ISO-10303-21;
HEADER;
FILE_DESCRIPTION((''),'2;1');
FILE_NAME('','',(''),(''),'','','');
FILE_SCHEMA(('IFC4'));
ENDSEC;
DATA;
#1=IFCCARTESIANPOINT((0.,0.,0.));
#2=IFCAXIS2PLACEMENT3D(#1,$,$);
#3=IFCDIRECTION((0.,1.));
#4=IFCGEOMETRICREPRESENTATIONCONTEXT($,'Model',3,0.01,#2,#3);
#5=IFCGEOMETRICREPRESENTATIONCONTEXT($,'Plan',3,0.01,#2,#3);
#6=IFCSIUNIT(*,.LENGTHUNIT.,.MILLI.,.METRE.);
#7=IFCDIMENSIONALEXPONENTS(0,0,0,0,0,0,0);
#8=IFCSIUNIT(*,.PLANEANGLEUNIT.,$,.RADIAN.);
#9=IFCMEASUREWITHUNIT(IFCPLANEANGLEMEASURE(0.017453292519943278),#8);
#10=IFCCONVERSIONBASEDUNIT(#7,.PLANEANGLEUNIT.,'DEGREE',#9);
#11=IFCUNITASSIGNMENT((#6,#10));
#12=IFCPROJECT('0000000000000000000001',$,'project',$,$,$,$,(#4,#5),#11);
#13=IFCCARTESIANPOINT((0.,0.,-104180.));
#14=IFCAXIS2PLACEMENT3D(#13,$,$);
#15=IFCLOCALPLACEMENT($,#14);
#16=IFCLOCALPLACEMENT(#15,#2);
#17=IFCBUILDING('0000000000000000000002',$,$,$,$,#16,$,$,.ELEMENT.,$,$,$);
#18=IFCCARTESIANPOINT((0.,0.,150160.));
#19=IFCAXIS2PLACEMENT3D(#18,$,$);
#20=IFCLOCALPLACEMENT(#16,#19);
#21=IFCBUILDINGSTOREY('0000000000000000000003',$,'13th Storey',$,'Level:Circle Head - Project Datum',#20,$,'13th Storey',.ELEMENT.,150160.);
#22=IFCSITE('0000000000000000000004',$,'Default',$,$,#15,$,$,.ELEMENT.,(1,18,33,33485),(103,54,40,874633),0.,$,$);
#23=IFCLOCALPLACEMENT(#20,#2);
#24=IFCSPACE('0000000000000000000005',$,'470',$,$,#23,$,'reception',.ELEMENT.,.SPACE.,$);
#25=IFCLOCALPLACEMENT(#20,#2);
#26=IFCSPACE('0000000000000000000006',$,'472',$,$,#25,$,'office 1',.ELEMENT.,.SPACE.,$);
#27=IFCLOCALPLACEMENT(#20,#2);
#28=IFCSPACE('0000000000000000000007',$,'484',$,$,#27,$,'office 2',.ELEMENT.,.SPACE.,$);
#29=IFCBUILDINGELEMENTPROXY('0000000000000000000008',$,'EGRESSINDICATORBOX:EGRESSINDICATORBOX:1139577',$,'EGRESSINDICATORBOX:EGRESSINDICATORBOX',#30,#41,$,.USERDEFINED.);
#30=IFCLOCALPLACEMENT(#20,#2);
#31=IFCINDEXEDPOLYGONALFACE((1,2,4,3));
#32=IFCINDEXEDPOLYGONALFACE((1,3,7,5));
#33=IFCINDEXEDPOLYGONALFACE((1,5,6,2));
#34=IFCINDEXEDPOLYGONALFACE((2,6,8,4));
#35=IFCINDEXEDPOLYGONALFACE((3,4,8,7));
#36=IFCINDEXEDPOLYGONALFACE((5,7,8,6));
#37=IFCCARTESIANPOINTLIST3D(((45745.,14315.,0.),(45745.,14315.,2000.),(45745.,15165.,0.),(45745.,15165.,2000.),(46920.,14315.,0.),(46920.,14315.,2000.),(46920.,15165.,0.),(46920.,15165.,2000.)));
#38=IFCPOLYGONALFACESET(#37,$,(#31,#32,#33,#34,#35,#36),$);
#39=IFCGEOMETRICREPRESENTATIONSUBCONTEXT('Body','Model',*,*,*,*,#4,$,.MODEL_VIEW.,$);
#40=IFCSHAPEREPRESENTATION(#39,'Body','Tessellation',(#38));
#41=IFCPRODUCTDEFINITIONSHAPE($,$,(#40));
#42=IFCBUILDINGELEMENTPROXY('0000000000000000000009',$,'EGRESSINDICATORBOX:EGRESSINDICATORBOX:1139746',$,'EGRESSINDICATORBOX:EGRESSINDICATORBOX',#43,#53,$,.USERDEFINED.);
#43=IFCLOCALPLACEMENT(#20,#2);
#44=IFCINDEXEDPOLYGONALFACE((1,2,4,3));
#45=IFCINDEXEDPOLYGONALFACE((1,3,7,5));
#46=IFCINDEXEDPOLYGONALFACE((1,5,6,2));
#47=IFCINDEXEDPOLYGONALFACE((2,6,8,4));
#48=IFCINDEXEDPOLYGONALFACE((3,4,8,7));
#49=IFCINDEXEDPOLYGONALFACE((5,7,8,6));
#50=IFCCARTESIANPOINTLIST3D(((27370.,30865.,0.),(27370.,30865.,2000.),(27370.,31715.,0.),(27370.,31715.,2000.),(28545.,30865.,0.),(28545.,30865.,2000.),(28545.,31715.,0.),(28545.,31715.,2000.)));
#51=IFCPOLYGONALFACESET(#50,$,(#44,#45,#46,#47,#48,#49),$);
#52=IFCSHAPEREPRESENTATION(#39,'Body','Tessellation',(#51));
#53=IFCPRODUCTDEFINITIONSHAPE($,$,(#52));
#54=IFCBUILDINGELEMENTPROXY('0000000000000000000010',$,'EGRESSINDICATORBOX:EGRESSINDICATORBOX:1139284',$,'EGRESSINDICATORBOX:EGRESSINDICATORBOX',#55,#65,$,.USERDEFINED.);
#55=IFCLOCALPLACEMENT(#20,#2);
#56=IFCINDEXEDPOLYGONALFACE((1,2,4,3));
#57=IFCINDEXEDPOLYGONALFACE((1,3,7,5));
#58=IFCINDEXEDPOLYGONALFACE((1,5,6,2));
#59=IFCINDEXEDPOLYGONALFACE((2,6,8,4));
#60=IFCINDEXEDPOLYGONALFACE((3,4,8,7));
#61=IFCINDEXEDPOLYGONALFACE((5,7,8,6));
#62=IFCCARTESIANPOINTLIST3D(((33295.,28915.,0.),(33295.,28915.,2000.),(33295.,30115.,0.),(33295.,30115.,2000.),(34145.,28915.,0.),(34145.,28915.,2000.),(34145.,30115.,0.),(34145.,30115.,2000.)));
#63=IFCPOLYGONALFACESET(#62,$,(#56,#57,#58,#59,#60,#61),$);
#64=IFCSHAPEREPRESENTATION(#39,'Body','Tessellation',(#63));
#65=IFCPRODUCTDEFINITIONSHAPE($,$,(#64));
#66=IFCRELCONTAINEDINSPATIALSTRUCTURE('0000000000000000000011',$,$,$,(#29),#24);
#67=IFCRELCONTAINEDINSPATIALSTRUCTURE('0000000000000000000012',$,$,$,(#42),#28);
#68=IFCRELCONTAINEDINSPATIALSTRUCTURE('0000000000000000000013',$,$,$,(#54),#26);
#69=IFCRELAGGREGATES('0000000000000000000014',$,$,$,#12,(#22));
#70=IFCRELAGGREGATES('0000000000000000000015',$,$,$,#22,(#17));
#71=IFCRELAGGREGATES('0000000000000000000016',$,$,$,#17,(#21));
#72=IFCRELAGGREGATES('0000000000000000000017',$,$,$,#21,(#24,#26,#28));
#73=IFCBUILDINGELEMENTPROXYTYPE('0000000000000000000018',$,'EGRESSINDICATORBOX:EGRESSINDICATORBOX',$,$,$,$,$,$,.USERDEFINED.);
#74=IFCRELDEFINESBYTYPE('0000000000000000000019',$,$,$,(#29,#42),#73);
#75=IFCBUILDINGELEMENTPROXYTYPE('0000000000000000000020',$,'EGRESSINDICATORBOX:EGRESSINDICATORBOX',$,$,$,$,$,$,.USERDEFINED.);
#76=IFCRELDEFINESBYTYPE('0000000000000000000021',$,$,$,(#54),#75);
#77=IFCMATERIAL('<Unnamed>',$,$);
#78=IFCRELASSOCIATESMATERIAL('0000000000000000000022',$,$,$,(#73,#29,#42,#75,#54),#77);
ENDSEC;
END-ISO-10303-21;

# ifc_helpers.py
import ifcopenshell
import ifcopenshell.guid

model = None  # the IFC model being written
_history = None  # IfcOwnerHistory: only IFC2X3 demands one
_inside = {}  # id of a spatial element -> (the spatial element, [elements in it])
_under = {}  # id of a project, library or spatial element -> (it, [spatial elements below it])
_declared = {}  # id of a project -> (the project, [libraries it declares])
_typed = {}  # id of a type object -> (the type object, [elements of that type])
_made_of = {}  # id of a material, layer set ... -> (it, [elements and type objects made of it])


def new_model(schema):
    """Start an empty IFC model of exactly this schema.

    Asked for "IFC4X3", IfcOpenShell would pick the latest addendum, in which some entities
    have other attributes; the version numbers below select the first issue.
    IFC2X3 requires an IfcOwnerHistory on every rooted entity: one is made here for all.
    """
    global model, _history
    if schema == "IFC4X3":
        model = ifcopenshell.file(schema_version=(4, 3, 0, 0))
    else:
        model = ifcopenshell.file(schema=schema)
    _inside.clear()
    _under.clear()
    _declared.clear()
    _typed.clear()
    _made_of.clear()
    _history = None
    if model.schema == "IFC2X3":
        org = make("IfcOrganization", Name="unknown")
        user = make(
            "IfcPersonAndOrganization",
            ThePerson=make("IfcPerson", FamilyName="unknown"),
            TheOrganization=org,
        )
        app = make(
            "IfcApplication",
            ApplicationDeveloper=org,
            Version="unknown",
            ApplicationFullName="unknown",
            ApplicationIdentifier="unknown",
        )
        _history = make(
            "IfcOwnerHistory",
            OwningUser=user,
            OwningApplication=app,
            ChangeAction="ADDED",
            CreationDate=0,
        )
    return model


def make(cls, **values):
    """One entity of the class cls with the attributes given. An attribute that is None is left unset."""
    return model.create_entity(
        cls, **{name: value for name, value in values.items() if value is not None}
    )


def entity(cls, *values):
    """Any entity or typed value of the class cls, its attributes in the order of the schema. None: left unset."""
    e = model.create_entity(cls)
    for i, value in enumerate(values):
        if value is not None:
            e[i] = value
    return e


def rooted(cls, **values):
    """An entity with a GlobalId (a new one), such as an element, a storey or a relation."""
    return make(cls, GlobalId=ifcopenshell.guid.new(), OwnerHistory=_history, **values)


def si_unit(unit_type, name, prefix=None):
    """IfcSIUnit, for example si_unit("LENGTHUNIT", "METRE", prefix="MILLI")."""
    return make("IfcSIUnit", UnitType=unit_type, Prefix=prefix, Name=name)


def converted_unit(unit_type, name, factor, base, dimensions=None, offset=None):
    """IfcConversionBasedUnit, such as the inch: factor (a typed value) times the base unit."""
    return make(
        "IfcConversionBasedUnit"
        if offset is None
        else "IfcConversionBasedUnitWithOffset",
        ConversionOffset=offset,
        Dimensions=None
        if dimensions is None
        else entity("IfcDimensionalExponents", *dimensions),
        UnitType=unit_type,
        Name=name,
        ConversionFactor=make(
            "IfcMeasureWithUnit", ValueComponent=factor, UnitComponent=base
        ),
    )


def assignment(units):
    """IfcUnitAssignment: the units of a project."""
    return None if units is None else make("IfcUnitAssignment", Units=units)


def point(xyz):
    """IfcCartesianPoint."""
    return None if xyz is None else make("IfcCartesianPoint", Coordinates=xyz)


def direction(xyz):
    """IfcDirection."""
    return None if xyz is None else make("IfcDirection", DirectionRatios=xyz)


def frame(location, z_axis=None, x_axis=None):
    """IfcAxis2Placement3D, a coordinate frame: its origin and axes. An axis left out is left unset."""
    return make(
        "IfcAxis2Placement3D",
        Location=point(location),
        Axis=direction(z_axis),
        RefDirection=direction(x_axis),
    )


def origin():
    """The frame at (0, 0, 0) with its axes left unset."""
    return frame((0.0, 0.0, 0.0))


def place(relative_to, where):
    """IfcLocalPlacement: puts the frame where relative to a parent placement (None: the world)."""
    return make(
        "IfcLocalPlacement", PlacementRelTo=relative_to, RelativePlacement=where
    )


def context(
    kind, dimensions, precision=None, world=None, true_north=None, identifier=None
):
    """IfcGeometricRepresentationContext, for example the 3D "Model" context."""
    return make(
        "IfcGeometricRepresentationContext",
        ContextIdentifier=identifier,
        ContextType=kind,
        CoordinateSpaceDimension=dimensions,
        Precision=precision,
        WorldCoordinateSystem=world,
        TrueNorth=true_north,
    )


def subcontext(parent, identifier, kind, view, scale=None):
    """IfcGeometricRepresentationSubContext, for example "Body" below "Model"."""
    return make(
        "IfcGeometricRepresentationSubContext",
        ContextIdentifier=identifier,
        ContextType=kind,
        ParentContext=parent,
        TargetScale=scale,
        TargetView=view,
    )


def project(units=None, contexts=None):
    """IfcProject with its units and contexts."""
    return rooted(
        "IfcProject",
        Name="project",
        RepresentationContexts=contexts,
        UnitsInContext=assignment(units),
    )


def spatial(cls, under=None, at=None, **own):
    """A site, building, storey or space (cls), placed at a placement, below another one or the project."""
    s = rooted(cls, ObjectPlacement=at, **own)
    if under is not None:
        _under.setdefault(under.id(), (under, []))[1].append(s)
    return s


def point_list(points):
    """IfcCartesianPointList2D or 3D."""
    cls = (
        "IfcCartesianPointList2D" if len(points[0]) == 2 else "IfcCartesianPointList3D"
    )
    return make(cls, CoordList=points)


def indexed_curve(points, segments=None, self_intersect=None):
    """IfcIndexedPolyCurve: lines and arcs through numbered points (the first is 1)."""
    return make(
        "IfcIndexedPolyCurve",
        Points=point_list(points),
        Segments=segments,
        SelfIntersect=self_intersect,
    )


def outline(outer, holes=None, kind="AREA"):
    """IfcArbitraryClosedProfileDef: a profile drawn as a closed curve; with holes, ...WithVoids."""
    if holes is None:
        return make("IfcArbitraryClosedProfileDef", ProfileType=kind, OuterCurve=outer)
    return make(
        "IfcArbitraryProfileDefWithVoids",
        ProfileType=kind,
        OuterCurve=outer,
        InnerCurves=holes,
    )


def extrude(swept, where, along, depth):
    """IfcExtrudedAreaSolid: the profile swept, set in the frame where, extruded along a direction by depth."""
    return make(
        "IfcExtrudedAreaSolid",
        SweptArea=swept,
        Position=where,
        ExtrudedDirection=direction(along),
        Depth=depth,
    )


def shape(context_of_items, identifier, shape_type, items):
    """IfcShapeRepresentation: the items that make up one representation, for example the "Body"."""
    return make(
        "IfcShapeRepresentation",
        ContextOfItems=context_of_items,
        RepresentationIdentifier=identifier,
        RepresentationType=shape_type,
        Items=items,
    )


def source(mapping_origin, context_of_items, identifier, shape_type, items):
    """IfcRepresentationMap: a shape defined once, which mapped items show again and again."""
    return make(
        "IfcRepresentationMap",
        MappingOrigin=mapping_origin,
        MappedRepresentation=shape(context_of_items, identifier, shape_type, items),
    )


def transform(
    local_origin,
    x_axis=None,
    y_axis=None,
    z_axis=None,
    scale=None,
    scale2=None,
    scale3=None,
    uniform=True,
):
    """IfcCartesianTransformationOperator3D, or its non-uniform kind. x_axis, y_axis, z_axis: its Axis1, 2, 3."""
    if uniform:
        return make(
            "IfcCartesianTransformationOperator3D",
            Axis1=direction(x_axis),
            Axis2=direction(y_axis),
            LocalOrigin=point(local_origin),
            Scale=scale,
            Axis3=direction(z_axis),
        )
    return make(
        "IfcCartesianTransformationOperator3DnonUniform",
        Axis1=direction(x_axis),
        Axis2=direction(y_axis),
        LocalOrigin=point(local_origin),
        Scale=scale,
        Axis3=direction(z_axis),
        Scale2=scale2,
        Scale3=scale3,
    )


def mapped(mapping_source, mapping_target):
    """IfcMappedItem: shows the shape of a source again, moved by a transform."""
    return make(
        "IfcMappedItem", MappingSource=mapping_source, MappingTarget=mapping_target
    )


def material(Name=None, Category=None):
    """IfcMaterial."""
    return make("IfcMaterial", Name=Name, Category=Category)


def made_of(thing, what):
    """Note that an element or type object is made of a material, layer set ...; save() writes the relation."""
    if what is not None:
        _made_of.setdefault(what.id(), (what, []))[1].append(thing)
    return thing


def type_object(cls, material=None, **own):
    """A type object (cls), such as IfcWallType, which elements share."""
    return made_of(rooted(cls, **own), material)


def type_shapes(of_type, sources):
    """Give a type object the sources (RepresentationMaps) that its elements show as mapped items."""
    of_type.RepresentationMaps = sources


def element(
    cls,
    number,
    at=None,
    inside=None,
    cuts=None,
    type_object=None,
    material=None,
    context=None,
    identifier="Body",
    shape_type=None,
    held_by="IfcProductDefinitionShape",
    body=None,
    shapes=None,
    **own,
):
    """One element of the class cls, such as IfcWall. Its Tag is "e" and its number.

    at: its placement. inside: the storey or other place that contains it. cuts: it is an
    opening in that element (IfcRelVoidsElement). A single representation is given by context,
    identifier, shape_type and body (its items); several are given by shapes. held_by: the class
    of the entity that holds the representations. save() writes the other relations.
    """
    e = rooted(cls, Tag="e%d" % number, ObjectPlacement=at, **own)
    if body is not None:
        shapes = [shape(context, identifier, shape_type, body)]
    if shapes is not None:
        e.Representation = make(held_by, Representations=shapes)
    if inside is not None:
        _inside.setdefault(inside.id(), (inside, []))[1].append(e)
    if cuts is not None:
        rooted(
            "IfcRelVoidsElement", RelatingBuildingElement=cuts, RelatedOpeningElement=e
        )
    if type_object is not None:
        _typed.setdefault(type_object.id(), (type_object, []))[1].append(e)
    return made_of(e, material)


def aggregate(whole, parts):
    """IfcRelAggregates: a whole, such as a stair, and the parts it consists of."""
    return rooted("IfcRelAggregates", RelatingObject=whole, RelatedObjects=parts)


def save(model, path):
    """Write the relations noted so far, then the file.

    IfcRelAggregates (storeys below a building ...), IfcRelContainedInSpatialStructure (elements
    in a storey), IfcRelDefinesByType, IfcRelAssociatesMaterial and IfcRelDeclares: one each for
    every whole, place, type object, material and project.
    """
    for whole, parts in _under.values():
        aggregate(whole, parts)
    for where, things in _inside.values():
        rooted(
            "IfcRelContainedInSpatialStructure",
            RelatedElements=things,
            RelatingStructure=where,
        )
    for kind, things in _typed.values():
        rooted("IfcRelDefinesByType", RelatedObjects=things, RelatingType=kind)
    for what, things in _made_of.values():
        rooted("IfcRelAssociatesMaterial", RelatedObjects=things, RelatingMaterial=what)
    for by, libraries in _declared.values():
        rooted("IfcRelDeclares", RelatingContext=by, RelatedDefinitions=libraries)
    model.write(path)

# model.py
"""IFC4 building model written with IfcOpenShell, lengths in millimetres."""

from ifc_helpers import new_model, entity, si_unit, converted_unit, direction, frame, origin, place, context, subcontext, project, spatial, indexed_curve, outline, extrude, source, transform, mapped, material, type_object, type_shapes, element, save


model = new_model("IFC4")

# Units and contexts
model_context = context("Model", 3, precision=0.01, world=origin(), true_north=direction((0.0, 1.0)))
plan_context = context("Plan", 3, precision=0.01, world=origin(), true_north=direction((0.0, 1.0)))
body_context = subcontext(model_context, "Body", "Model", "MODEL_VIEW")
ifc_project = project(units=[si_unit("LENGTHUNIT", "METRE", prefix="MILLI"), converted_unit("PLANEANGLEUNIT", "DEGREE", entity("IfcPlaneAngleMeasure", 0.017453292519943278), si_unit("PLANEANGLEUNIT", "RADIAN"), dimensions=[0, 0, 0, 0, 0, 0, 0])], contexts=[model_context, plan_context])

# Site, building, storey
site_placement = place(None, frame((0.0, 0.0, -104180.0)))
site = spatial("IfcSite", under=ifc_project, at=site_placement, Name="Default", CompositionType="ELEMENT", RefLatitude=(1, 18, 33, 33485), RefLongitude=(103, 54, 40, 874633), RefElevation=0.0)
building_placement = place(site_placement, origin())
building = spatial("IfcBuilding", under=site, at=building_placement, CompositionType="ELEMENT")
storey_placement = place(building_placement, frame((0.0, 0.0, 150160.0)))
storey = spatial("IfcBuildingStorey", under=building, at=storey_placement, Name="13th Storey", ObjectType="Level:Circle Head - Project Datum", LongName="13th Storey", CompositionType="ELEMENT", Elevation=150160.0)

# Shared definitions
space_1_placement = place(storey_placement, origin())
space_1 = spatial("IfcSpace", under=storey, at=space_1_placement, Name="470", LongName="reception", CompositionType="ELEMENT", PredefinedType="SPACE")

# Shared definitions
ifc_material_1 = material(Name="<Unnamed>")

# Shared definitions
space_2_placement = place(storey_placement, origin())
space_2 = spatial("IfcSpace", under=storey, at=space_2_placement, Name="472", LongName="office 1", CompositionType="ELEMENT", PredefinedType="SPACE")

# Shared definitions
building_element_proxy_type_1 = type_object("IfcBuildingElementProxyType", Name="EGRESSINDICATORBOX:EGRESSINDICATORBOX", PredefinedType="USERDEFINED", material=ifc_material_1)
shared_shape_1 = source(origin(), body_context, "Body", "SweptSolid", [
    extrude(outline(indexed_curve([(-425.0, -587.5), (425.0, -587.5), (425.0, 587.5), (-425.0, 587.5), (-425.0, -587.5)], self_intersect=False)), frame((0.0, 0.0, 0.0), z_axis=(0.0, 0.0, 1.0), x_axis=(-1.0, 0.0, 0.0)), (0.0, 0.0, 1.0), 2000.0),
])
type_shapes(building_element_proxy_type_1, [shared_shape_1])

# Building element proxy
for number, where, z_axis, x_axis, name in (
    (1, (46332.5, 14740.0, 0.0), (0.0, 0.0, 1.0), (0.0, -1.0, 0.0), "EGRESSINDICATORBOX:EGRESSINDICATORBOX:1139577"),
):
    element("IfcBuildingElementProxy", number, at=place(space_1_placement, frame(where, z_axis=z_axis, x_axis=x_axis)), inside=space_1, type_object=building_element_proxy_type_1, material=ifc_material_1, Name=name, ObjectType="EGRESSINDICATORBOX:EGRESSINDICATORBOX", PredefinedType="USERDEFINED", context=body_context, shape_type="MappedRepresentation", body=[
        mapped(shared_shape_1, transform((0.0, 0.0, 0.0), scale=1.0)),
    ])

# Shared definitions
space_3_placement = place(storey_placement, origin())
space_3 = spatial("IfcSpace", under=storey, at=space_3_placement, Name="484", LongName="office 2", CompositionType="ELEMENT", PredefinedType="SPACE")

# Building element proxies
proxy_1_placement = place(space_3_placement, frame((27957.5, 31290.0, 0.0), z_axis=(0.0, 0.0, 1.0), x_axis=(0.0, 1.0, 0.0)))
element("IfcBuildingElementProxy", 2, at=proxy_1_placement, inside=space_3, type_object=building_element_proxy_type_1, material=ifc_material_1, Name="EGRESSINDICATORBOX:EGRESSINDICATORBOX:1139746", ObjectType="EGRESSINDICATORBOX:EGRESSINDICATORBOX", PredefinedType="USERDEFINED", context=body_context, shape_type="MappedRepresentation", body=[
    mapped(shared_shape_1, transform((0.0, 0.0, 0.0), scale=1.0)),
])
building_element_proxy_type_2 = type_object("IfcBuildingElementProxyType", Name="EGRESSINDICATORBOX:EGRESSINDICATORBOX", PredefinedType="USERDEFINED", material=ifc_material_1)
shared_shape_2 = source(origin(), body_context, "Body", "SweptSolid", [
    extrude(outline(indexed_curve([(-425.0, -600.0), (425.0, -600.0), (425.0, 600.0), (-425.0, 600.0), (-425.0, -600.0)], self_intersect=False)), frame((0.0, 0.0, 0.0), z_axis=(0.0, 0.0, 1.0), x_axis=(-1.0, 0.0, 0.0)), (0.0, 0.0, 1.0), 2000.0),
])
type_shapes(building_element_proxy_type_2, [shared_shape_2])
proxy_2_placement = place(space_2_placement, frame((33720.0, 29515.0, 0.0)))
element("IfcBuildingElementProxy", 3, at=proxy_2_placement, inside=space_2, type_object=building_element_proxy_type_2, material=ifc_material_1, Name="EGRESSINDICATORBOX:EGRESSINDICATORBOX:1139284", ObjectType="EGRESSINDICATORBOX:EGRESSINDICATORBOX", PredefinedType="USERDEFINED", context=body_context, shape_type="MappedRepresentation", body=[
    mapped(shared_shape_2, transform((0.0, 0.0, 0.0), scale=1.0)),
])

save(model, "model.ifc")
